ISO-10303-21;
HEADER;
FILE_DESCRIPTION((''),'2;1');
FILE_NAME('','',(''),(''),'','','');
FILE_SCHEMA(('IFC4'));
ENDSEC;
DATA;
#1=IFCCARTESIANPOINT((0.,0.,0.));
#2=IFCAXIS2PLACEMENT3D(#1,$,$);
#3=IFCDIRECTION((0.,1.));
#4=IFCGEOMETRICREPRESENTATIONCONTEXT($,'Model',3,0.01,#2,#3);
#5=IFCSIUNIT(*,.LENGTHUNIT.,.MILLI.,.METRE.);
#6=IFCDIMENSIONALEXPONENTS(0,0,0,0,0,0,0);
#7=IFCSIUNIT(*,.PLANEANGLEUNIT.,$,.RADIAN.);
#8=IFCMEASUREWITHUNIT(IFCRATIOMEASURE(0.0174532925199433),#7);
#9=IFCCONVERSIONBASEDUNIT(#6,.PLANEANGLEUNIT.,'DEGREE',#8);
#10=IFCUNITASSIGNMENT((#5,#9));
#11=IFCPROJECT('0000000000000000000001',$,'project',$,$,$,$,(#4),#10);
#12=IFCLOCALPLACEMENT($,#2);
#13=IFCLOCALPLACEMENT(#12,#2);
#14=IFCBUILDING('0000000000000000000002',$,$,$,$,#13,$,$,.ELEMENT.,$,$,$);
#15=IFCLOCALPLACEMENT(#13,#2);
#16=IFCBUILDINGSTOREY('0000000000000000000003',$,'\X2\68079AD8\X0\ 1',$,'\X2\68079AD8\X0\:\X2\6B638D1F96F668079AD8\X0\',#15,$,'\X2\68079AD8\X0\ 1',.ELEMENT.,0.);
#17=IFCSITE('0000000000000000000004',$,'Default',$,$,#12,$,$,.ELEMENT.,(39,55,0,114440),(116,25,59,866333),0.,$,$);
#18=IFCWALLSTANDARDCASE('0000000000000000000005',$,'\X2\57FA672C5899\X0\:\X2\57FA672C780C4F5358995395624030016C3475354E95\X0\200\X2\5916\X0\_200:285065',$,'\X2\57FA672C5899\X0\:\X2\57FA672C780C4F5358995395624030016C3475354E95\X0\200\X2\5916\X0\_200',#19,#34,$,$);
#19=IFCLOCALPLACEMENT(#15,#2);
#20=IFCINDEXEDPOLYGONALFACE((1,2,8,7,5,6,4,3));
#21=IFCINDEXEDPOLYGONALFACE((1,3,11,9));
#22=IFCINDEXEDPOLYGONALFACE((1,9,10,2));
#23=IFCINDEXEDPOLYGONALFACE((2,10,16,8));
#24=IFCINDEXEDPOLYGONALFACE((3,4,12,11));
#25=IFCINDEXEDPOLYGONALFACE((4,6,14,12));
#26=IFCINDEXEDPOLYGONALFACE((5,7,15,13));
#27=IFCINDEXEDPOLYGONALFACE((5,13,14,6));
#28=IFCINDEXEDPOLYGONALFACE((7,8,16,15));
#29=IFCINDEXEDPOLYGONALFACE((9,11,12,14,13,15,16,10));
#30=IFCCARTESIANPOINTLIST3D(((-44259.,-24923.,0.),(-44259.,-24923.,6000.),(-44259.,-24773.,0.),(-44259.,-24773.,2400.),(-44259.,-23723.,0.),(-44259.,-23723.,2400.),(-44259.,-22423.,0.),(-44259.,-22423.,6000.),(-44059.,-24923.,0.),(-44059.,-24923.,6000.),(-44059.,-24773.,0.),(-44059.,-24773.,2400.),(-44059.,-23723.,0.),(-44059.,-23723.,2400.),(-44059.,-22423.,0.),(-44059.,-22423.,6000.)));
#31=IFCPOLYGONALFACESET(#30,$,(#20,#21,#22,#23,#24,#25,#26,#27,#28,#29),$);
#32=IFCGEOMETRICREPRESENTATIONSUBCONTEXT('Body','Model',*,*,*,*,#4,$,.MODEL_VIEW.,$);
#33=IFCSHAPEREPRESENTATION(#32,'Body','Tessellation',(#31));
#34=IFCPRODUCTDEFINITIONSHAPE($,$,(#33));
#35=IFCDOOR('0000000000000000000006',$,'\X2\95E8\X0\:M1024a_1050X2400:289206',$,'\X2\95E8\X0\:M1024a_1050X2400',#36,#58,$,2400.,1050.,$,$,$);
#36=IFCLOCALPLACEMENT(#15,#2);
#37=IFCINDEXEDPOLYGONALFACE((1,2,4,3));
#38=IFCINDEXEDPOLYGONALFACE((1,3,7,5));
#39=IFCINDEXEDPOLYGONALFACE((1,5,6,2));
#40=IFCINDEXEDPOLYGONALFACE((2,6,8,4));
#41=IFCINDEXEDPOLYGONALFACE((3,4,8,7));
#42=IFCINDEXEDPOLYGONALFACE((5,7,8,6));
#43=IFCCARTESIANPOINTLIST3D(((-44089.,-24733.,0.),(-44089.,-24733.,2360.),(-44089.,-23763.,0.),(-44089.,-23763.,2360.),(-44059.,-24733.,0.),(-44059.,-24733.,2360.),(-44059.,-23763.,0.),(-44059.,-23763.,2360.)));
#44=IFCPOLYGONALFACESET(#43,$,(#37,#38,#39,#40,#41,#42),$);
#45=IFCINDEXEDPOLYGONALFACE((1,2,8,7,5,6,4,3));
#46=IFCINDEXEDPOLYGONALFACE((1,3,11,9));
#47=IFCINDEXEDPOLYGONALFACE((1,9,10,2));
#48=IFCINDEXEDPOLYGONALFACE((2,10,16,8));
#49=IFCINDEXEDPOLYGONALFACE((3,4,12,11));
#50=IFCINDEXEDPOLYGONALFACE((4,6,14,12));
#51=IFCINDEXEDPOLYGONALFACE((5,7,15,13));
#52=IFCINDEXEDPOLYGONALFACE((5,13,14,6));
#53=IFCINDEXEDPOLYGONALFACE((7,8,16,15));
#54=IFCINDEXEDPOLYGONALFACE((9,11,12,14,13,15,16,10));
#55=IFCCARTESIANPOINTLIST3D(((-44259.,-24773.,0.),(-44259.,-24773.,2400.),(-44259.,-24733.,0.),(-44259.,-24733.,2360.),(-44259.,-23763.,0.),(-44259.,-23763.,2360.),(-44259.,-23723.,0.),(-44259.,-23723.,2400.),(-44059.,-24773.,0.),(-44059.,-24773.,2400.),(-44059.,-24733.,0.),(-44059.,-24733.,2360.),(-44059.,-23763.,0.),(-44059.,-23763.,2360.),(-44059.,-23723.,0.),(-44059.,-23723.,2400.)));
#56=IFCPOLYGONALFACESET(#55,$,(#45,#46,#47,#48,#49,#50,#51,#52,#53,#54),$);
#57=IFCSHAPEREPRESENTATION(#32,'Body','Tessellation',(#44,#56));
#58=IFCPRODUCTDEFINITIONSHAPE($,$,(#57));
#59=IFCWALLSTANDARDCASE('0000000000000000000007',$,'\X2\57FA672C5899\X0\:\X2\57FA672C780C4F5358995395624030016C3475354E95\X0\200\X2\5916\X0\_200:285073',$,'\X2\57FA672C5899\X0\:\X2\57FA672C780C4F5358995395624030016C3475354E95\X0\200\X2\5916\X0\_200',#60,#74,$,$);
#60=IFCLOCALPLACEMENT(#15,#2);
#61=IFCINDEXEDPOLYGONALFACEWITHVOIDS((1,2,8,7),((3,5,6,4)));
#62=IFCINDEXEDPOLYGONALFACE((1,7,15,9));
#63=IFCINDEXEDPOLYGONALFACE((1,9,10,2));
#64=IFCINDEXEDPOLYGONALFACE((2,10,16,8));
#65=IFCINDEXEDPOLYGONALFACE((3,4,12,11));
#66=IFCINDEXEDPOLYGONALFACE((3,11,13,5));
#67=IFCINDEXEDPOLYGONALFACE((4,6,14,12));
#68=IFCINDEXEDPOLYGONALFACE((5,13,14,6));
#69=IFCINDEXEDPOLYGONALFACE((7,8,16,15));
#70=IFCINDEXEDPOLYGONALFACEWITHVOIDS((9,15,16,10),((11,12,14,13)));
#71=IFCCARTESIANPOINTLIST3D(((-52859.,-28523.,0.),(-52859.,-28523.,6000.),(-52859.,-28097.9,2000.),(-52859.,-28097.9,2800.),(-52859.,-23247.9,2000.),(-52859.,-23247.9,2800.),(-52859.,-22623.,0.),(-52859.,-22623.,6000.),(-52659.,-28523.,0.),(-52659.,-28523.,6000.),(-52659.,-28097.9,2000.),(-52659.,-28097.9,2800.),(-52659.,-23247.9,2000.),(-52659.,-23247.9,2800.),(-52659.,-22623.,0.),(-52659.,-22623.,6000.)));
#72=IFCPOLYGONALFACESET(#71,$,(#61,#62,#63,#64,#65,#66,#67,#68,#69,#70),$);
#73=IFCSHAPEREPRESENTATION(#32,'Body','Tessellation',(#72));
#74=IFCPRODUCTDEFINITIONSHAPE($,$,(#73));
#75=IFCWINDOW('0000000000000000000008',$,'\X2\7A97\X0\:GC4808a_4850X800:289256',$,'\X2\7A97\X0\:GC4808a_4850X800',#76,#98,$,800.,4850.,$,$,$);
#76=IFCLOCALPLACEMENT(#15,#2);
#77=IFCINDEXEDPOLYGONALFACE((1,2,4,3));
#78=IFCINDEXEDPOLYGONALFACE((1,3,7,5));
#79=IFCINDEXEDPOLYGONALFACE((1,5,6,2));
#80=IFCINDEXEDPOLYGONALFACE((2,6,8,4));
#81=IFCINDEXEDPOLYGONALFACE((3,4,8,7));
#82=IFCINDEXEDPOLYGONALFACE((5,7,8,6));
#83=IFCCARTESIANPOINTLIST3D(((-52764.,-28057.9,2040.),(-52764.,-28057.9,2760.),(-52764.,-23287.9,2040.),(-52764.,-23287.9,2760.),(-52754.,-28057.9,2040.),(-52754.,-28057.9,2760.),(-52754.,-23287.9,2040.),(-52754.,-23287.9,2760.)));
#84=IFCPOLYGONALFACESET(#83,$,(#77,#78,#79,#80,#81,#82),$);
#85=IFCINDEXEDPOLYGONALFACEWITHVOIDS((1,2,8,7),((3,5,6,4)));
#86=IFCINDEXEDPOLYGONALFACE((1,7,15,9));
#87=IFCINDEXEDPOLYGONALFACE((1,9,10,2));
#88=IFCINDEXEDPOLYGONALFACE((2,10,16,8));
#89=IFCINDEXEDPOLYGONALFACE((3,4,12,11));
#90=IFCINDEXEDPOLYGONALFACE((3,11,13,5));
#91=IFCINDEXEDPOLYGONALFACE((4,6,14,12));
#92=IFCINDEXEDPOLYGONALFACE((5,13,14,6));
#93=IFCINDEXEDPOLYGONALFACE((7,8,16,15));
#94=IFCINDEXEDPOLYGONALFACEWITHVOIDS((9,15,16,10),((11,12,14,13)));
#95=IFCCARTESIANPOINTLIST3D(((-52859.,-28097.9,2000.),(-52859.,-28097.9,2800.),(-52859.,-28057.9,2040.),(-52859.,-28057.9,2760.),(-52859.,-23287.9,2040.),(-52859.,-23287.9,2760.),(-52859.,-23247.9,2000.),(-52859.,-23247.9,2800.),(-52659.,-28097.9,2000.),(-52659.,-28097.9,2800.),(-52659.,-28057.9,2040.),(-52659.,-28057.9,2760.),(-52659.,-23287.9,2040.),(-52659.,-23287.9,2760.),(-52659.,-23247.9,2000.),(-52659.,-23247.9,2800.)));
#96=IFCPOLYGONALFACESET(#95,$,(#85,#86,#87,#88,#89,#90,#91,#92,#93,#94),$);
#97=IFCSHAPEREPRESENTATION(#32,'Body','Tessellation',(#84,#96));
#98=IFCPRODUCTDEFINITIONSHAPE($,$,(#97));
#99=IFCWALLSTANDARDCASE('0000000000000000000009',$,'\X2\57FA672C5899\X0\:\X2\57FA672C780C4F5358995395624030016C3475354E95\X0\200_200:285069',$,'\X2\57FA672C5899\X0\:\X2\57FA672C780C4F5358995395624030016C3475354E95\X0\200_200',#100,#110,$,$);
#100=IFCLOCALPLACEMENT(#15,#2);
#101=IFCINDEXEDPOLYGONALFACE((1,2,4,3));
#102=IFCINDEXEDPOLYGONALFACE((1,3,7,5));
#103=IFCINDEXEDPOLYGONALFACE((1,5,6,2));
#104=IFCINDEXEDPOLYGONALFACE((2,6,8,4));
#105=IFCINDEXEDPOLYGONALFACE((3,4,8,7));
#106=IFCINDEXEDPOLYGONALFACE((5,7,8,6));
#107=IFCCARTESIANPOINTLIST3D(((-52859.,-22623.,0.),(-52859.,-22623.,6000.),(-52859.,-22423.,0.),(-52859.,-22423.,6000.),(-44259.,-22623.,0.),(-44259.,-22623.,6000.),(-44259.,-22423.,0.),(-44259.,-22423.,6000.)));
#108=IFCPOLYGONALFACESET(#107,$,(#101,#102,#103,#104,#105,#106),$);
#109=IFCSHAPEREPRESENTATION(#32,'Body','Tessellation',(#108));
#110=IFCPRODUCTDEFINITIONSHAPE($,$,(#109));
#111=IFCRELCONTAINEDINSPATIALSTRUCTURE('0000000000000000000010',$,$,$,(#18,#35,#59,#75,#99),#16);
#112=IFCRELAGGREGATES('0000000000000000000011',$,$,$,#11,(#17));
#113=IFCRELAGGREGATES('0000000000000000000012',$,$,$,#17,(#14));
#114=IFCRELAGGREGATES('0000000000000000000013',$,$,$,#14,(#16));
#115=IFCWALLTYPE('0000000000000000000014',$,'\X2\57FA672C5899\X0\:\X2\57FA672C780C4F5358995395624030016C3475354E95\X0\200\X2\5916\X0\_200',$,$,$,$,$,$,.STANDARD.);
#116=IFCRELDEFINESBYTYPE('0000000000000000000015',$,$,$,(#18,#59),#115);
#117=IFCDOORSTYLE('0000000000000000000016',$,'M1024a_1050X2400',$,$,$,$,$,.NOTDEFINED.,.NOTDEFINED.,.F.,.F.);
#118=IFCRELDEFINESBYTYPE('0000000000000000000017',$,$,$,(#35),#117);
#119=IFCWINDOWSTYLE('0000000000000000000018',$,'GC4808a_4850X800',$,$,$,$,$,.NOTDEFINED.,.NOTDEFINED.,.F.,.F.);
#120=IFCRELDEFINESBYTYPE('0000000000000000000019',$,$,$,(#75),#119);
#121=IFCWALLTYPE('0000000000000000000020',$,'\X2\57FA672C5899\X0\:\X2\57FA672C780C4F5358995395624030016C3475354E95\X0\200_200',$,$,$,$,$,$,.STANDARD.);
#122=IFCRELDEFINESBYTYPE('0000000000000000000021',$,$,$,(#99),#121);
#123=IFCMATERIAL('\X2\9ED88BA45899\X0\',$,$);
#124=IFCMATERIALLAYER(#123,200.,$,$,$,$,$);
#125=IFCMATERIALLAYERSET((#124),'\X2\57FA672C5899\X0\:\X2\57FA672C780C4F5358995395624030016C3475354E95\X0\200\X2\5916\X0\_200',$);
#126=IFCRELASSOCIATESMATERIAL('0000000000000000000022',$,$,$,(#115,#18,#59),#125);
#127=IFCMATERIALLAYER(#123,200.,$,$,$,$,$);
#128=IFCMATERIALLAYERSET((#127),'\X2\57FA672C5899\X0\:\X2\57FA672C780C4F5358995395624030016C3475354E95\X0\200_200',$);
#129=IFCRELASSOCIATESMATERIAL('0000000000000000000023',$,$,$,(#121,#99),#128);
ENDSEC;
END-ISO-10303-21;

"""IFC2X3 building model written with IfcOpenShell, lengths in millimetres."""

from ifc_helpers import new_model, entity, si_unit, converted_unit, direction, frame, frame_2d, origin, origin_2d_with_axis, place, context, subcontext, project, spatial, polyline, rectangle, outline, extrude, source, transform, mapped, material, layer, layer_set, layer_usage, type_object, type_shapes, element, fill, save


model = new_model("IFC2X3")

# Units and contexts
model_context = context("Model", 3, precision=0.01, world=origin(), true_north=direction((0.0, 1.0)))
body_context = subcontext(model_context, "Body", "Model", "MODEL_VIEW")
ifc_project = project(units=[si_unit("LENGTHUNIT", "METRE", prefix="MILLI"), converted_unit("PLANEANGLEUNIT", "DEGREE", entity("IfcRatioMeasure", 0.0174532925199433), si_unit("PLANEANGLEUNIT", "RADIAN"), dimensions=[0, 0, 0, 0, 0, 0, 0])], contexts=[model_context])

# Site, building, storey
site_placement = place(None, origin())
site = spatial("IfcSite", under=ifc_project, at=site_placement, Name="Default", CompositionType="ELEMENT", RefLatitude=(39, 55, 0, 114440), RefLongitude=(116, 25, 59, 866333), RefElevation=0.0)
building_placement = place(site_placement, origin())
building = spatial("IfcBuilding", under=site, at=building_placement, CompositionType="ELEMENT")
storey_placement = place(building_placement, origin())
storey = spatial("IfcBuildingStorey", under=building, at=storey_placement, Name="标高 1", ObjectType="标高:正负零标高", LongName="标高 1", CompositionType="ELEMENT", Elevation=0.0)

# Shared definitions
ifc_material = material(Name="默认墙")
ifc_layer_1 = layer(ifc_material, 200.0)
ifc_layer_set_1 = layer_set([ifc_layer_1], Name="基本墙:基本砌体墙厕所、水电井200外_200")
wall_type_1 = type_object("IfcWallType", Name="基本墙:基本砌体墙厕所、水电井200外_200", PredefinedType="STANDARD", material=ifc_layer_set_1)

# Wall, opening, door
ifc_layer_usage_1 = layer_usage(ifc_layer_set_1, "AXIS2", "NEGATIVE", 100.0)
wall_1_placement = place(building_placement, frame((-44159.0, -22423.0, 0.0), z_axis=(0.0, 0.0, 1.0), x_axis=(0.0, -1.0, 0.0)))
wall_1 = element("IfcWallStandardCase", 1, at=wall_1_placement, inside=storey, type_object=wall_type_1, material=ifc_layer_usage_1, Name="基本墙:基本砌体墙厕所、水电井200外_200:285065", ObjectType="基本墙:基本砌体墙厕所、水电井200外_200", context=body_context, shape_type="SweptSolid", body=[
    extrude(rectangle(XDim=2500.0, YDim=200.0, at=frame_2d((1250.0, 0.0), x_axis=(-1.0, 0.0))), origin(), (0.0, 0.0, 1.0), 6000.0),
])
opening_1_placement = place(wall_1_placement, frame((1300.0, -100.0, 0.0)))
opening_1 = element("IfcOpeningElement", 2, at=opening_1_placement, cuts=wall_1, ObjectType="Opening", context=body_context, shape_type="SweptSolid", body=[
    extrude(rectangle(XDim=2400.0, YDim=1050.0, at=frame_2d((1200.0, 525.0), x_axis=(1.0, 0.0))), frame((0.0, 0.0, 0.0), z_axis=(0.0, 1.0, 0.0), x_axis=(0.0, 0.0, 1.0)), (0.0, 0.0, 1.0), 200.0),
])
door_style = type_object("IfcDoorStyle", Name="M1024a_1050X2400", ConstructionType="NOTDEFINED", OperationType="NOTDEFINED", ParameterTakesPrecedence=False, Sizeable=False)
shared_shape_1 = source(origin(), body_context, "Body", "SweptSolid", [
    extrude(rectangle(XDim=30.0, YDim=970.0, at=frame_2d((0.0, 0.0), x_axis=(1.0, 0.0))), frame((525.0, -715.0, 0.0), z_axis=(0.0, 0.0, 1.0), x_axis=(0.0, 1.0, 0.0)), (0.0, 0.0, 1.0), 2360.0),
    extrude(outline(polyline([(-1170.0, 485.0), (1190.0, 485.0), (1190.0, 525.0), (-1210.0, 525.0), (-1210.0, -525.0), (1190.0, -525.0), (1190.0, -485.0), (-1170.0, -485.0), (-1170.0, 485.0)])), frame((525.0, -900.0, 1190.0), z_axis=(0.0, 1.0, 0.0), x_axis=(0.0, 0.0, -1.0)), (0.0, 0.0, 1.0), 200.0),
])
type_shapes(door_style, [shared_shape_1])
door_placement = place(opening_1_placement, frame((0.0, 900.0, 0.0)))
door = element("IfcDoor", 3, at=door_placement, inside=storey, type_object=door_style, Name="门:M1024a_1050X2400:289206", ObjectType="门:M1024a_1050X2400", OverallHeight=2400.0, OverallWidth=1050.0, context=body_context, shape_type="MappedRepresentation", body=[
    mapped(shared_shape_1, transform((0.0, 0.0, 0.0), scale=1.0)),
])
fill(opening_1, door)

# Wall, opening, window
ifc_layer_usage_2 = layer_usage(ifc_layer_set_1, "AXIS2", "NEGATIVE", 100.0)
wall_2_placement = place(building_placement, frame((-52759.0, -22623.0, 0.0), z_axis=(0.0, 0.0, 1.0), x_axis=(0.0, -1.0, 0.0)))
wall_2 = element("IfcWallStandardCase", 4, at=wall_2_placement, inside=storey, type_object=wall_type_1, material=ifc_layer_usage_2, Name="基本墙:基本砌体墙厕所、水电井200外_200:285073", ObjectType="基本墙:基本砌体墙厕所、水电井200外_200", context=body_context, shape_type="SweptSolid", body=[
    extrude(rectangle(XDim=5900.0, YDim=200.0, at=frame_2d((2950.0, 0.0), x_axis=(-1.0, 0.0))), origin(), (0.0, 0.0, 1.0), 6000.0),
])
opening_2_placement = place(wall_2_placement, frame((624.9, -100.0, 2000.0)))
opening_2 = element("IfcOpeningElement", 5, at=opening_2_placement, cuts=wall_2, ObjectType="Opening", context=body_context, shape_type="SweptSolid", body=[
    extrude(rectangle(XDim=800.0, YDim=4850.0, at=frame_2d((400.0, 2425.0), x_axis=(1.0, 0.0))), frame((0.0, 0.0, 0.0), z_axis=(0.0, 1.0, 0.0), x_axis=(0.0, 0.0, 1.0)), (0.0, 0.0, 1.0), 200.0),
])
window_style = type_object("IfcWindowStyle", Name="GC4808a_4850X800", ConstructionType="NOTDEFINED", OperationType="NOTDEFINED", ParameterTakesPrecedence=False, Sizeable=False)
shared_shape_2 = source(origin(), body_context, "Body", "SweptSolid", [
    extrude(rectangle(XDim=10.0, YDim=4770.0, at=origin_2d_with_axis()), frame((2425.0, -800.0, 40.0), z_axis=(0.0, 0.0, 1.0), x_axis=(0.0, 1.0, 0.0)), (0.0, 0.0, 1.0), 720.0),
    extrude(outline(polyline([(-2425.0, -400.0), (2425.0, -400.0), (2425.0, 400.0), (-2425.0, 400.0), (-2425.0, -400.0)]), holes=[polyline([(2385.0, 360.0), (2385.0, -360.0), (-2385.0, -360.0), (-2385.0, 360.0), (2385.0, 360.0)])]), frame((2425.0, -900.0, 400.0), z_axis=(0.0, 1.0, 0.0), x_axis=(-1.0, 0.0, 0.0)), (0.0, 0.0, 1.0), 200.0),
])
type_shapes(window_style, [shared_shape_2])
window_placement = place(opening_2_placement, frame((0.0, 900.0, 0.0)))
window = element("IfcWindow", 6, at=window_placement, inside=storey, type_object=window_style, Name="窗:GC4808a_4850X800:289256", ObjectType="窗:GC4808a_4850X800", OverallHeight=800.0, OverallWidth=4850.0, context=body_context, shape_type="MappedRepresentation", body=[
    mapped(shared_shape_2, transform((0.0, 0.0, 0.0), scale=1.0)),
])
fill(opening_2, window)

# Wall
ifc_layer_2 = layer(ifc_material, 200.0)
ifc_layer_set_2 = layer_set([ifc_layer_2], Name="基本墙:基本砌体墙厕所、水电井200_200")
ifc_layer_usage_3 = layer_usage(ifc_layer_set_2, "AXIS2", "NEGATIVE", 100.0)
wall_type_2 = type_object("IfcWallType", Name="基本墙:基本砌体墙厕所、水电井200_200", PredefinedType="STANDARD", material=ifc_layer_set_2)
wall_3_placement = place(building_placement, frame((-52859.0, -22523.0, 0.0)))
element("IfcWallStandardCase", 7, at=wall_3_placement, inside=storey, type_object=wall_type_2, material=ifc_layer_usage_3, Name="基本墙:基本砌体墙厕所、水电井200_200:285069", ObjectType="基本墙:基本砌体墙厕所、水电井200_200", context=body_context, shape_type="SweptSolid", body=[
    extrude(rectangle(XDim=8600.0, YDim=200.0, at=frame_2d((4300.0, 0.0), x_axis=(-1.0, 0.0))), origin(), (0.0, 0.0, 1.0), 6000.0),
])

save(model, "model.ifc")
